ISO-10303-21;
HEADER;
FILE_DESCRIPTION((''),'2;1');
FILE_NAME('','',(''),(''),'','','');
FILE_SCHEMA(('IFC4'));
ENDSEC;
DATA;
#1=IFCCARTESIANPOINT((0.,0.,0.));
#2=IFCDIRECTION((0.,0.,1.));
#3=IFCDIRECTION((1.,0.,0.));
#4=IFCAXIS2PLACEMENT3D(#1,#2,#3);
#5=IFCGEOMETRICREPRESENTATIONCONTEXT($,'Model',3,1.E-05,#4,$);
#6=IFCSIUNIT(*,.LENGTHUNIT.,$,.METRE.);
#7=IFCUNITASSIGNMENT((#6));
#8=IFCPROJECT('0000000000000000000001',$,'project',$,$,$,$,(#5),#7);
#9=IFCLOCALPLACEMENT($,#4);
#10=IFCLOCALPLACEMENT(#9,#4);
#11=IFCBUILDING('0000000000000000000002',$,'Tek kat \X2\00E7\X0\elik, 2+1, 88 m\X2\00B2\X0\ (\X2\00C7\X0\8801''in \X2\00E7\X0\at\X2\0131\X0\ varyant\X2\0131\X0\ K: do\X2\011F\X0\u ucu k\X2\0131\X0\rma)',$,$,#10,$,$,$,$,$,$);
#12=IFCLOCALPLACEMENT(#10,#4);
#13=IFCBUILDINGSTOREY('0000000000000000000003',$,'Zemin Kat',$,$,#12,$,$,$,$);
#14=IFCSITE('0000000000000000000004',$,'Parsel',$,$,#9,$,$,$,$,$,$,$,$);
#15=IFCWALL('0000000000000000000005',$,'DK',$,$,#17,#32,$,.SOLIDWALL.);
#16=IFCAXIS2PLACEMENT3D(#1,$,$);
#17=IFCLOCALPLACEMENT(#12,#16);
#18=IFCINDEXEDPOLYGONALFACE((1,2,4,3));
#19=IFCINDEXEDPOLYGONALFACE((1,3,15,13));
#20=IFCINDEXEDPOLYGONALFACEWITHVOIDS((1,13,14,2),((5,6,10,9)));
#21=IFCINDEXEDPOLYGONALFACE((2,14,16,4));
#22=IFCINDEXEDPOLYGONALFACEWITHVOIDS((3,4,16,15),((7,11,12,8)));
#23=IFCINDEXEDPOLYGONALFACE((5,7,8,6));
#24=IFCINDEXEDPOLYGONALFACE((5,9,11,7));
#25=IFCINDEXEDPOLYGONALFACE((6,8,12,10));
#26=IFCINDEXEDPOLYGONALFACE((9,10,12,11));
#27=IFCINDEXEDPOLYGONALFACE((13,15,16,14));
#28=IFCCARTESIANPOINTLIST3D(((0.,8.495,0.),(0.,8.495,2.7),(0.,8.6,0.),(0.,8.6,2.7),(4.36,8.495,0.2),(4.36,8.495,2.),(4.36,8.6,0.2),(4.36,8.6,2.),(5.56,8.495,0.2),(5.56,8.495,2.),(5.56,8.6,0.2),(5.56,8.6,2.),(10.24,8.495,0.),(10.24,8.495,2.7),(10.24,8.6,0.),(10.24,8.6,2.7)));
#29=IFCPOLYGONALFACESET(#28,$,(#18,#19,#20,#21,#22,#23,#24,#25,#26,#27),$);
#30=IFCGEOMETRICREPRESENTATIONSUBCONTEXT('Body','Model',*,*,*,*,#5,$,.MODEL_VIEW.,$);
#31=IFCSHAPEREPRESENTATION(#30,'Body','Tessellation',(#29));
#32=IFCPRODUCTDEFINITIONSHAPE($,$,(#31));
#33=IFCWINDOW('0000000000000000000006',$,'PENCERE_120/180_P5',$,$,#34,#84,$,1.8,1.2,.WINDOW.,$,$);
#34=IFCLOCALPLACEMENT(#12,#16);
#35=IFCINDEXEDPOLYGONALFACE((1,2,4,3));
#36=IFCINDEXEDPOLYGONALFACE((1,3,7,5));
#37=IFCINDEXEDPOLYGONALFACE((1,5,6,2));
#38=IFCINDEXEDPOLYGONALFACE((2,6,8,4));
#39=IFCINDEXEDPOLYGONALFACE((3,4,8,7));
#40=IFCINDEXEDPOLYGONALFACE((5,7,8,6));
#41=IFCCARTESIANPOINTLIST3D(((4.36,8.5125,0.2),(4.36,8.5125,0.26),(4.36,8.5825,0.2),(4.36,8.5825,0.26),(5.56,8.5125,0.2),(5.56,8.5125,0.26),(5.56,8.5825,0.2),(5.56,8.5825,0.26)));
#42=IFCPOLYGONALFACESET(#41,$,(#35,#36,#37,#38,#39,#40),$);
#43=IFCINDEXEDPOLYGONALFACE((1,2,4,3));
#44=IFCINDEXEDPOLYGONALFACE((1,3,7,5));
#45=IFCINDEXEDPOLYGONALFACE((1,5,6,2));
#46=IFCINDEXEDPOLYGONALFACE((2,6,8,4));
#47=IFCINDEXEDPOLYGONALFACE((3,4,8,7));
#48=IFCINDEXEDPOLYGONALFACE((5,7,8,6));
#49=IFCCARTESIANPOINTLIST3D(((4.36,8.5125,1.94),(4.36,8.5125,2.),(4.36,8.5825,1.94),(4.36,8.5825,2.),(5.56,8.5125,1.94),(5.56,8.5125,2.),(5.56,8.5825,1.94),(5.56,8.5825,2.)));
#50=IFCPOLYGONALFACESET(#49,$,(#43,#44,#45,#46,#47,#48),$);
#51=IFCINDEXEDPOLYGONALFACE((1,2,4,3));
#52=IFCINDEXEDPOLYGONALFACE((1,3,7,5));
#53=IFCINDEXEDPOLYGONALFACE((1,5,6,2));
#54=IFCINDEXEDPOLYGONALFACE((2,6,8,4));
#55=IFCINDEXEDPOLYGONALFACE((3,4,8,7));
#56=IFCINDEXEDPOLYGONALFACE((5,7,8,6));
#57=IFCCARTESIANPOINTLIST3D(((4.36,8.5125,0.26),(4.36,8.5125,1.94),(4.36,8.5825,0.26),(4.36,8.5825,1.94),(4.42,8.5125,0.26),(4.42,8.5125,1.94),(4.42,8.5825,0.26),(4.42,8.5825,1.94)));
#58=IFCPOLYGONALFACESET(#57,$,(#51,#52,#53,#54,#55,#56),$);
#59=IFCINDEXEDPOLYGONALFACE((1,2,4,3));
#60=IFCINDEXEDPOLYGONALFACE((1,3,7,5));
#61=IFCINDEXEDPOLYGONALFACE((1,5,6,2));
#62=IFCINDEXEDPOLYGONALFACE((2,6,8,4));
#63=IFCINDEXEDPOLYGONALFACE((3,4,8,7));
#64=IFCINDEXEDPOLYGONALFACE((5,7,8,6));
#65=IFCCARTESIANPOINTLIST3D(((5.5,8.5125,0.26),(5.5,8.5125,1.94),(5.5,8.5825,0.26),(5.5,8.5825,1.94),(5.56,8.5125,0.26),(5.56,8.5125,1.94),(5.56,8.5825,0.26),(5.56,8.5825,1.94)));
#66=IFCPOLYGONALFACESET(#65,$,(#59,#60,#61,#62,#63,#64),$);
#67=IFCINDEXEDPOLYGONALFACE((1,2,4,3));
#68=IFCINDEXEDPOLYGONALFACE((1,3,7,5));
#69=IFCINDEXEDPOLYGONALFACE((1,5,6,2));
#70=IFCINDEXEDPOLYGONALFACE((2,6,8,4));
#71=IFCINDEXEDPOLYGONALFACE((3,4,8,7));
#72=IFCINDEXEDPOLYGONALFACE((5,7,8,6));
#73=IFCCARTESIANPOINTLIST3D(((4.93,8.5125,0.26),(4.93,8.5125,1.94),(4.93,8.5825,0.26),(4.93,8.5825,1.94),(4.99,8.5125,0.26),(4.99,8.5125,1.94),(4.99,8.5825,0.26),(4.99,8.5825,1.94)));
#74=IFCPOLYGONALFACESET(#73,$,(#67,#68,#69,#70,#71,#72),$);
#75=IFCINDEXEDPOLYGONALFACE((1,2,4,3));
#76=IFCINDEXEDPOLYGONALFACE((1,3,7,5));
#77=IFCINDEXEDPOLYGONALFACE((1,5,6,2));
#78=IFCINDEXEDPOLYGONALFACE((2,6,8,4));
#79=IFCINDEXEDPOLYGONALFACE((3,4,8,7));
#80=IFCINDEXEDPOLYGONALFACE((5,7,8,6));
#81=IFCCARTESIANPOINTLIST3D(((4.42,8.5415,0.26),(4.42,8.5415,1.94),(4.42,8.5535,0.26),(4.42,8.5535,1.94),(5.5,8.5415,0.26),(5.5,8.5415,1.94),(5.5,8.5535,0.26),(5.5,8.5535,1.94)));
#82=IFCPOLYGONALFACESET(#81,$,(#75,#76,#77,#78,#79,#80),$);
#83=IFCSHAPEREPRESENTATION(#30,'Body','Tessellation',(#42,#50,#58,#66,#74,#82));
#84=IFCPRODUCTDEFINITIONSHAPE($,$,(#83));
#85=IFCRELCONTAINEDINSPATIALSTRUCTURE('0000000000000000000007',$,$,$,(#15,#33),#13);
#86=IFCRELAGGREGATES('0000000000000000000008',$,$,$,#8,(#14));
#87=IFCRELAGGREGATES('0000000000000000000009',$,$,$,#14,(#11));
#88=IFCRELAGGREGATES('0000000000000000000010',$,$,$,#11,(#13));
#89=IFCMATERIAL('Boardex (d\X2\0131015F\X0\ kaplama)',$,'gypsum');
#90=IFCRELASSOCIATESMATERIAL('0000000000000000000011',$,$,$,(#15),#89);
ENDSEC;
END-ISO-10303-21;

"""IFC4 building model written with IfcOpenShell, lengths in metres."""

from ifc_helpers import new_model, si_unit, frame, origin_with_axes, place, context, subcontext, project, spatial, line, indexed_curve, outline, extrude, material, element, fill, save


model = new_model("IFC4")

# Units and contexts
model_context = context("Model", 3, precision=1e-05, world=origin_with_axes())
body_context = subcontext(model_context, "Body", "Model", "MODEL_VIEW")
ifc_project = project(units=[si_unit("LENGTHUNIT", "METRE")], contexts=[model_context])

# Site, building, storey
site_placement = place(None, origin_with_axes())
site = spatial("IfcSite", under=ifc_project, at=site_placement, Name="Parsel")
building_placement = place(site_placement, origin_with_axes())
building = spatial("IfcBuilding", under=site, at=building_placement, Name="Tek kat çelik, 2+1, 88 m² (Ç8801'in çatı varyantı K: doğu ucu kırma)")
storey_placement = place(building_placement, origin_with_axes())
storey = spatial("IfcBuildingStorey", under=building, at=storey_placement, Name="Zemin Kat")

# Wall, opening, window
ifc_material = material(Name="Boardex (dış kaplama)", Category="gypsum")
wall_1_placement = place(storey_placement, origin_with_axes())
wall_1 = element("IfcWall", 1, at=wall_1_placement, inside=storey, material=ifc_material, Name="DK", PredefinedType="SOLIDWALL", context=body_context, shape_type="SweptSolid", body=[
    extrude(outline(indexed_curve([(0.0, 0.0), (10.24, 0.0), (10.24, 0.105), (0.0, 0.105)], segments=[line(1, 2, 3, 4, 1)])), frame((0.0, 8.495, 0.0), z_axis=(0.0, 0.0, 1.0), x_axis=(1.0, 0.0, 0.0)), (0.0, 0.0, 1.0), 2.7),
])
opening_1_placement = place(wall_1_placement, origin_with_axes())
opening_1 = element("IfcOpeningElement", 2, at=opening_1_placement, cuts=wall_1, PredefinedType="OPENING", context=body_context, shape_type="SweptSolid", body=[
    extrude(outline(indexed_curve([(0.0, 0.0), (1.2, 0.0), (1.2, 0.145), (0.0, 0.145)], segments=[line(1, 2, 3, 4, 1)])), frame((4.36, 8.475, 0.2), z_axis=(0.0, 0.0, 1.0), x_axis=(1.0, 0.0, 0.0)), (0.0, 0.0, 1.0), 1.8),
])
window_1_placement = place(storey_placement, origin_with_axes())
window_1 = element("IfcWindow", 3, at=window_1_placement, inside=storey, Name="PENCERE_120/180_P5", OverallHeight=1.8, OverallWidth=1.2, PredefinedType="WINDOW", context=body_context, shape_type="SweptSolid", body=[
    extrude(outline(indexed_curve([(0.0, 0.0), (1.2, 0.0), (1.2, 0.07), (0.0, 0.07)], segments=[line(1, 2, 3, 4, 1)])), frame((4.36, 8.5125, 0.2), z_axis=(0.0, 0.0, 1.0), x_axis=(1.0, 0.0, 0.0)), (0.0, 0.0, 1.0), 0.06),
    extrude(outline(indexed_curve([(0.0, 0.0), (1.2, 0.0), (1.2, 0.07), (0.0, 0.07)], segments=[line(1, 2, 3, 4, 1)])), frame((4.36, 8.5125, 1.94), z_axis=(0.0, 0.0, 1.0), x_axis=(1.0, 0.0, 0.0)), (0.0, 0.0, 1.0), 0.06),
    extrude(outline(indexed_curve([(0.0, 0.0), (0.06, 0.0), (0.06, 0.07), (0.0, 0.07)], segments=[line(1, 2, 3, 4, 1)])), frame((4.36, 8.5125, 0.26), z_axis=(0.0, 0.0, 1.0), x_axis=(1.0, 0.0, 0.0)), (0.0, 0.0, 1.0), 1.68),
    extrude(outline(indexed_curve([(0.0, 0.0), (0.06, 0.0), (0.06, 0.07), (0.0, 0.07)], segments=[line(1, 2, 3, 4, 1)])), frame((5.5, 8.5125, 0.26), z_axis=(0.0, 0.0, 1.0), x_axis=(1.0, 0.0, 0.0)), (0.0, 0.0, 1.0), 1.68),
    extrude(outline(indexed_curve([(0.0, 0.0), (0.06, 0.0), (0.06, 0.07), (0.0, 0.07)], segments=[line(1, 2, 3, 4, 1)])), frame((4.93, 8.5125, 0.26), z_axis=(0.0, 0.0, 1.0), x_axis=(1.0, 0.0, 0.0)), (0.0, 0.0, 1.0), 1.68),
    extrude(outline(indexed_curve([(0.0, 0.0), (1.08, 0.0), (1.08, 0.012), (0.0, 0.012)], segments=[line(1, 2, 3, 4, 1)])), frame((4.42, 8.5415, 0.26), z_axis=(0.0, 0.0, 1.0), x_axis=(1.0, 0.0, 0.0)), (0.0, 0.0, 1.0), 1.68),
])
fill(opening_1, window_1)

save(model, "model.ifc")
